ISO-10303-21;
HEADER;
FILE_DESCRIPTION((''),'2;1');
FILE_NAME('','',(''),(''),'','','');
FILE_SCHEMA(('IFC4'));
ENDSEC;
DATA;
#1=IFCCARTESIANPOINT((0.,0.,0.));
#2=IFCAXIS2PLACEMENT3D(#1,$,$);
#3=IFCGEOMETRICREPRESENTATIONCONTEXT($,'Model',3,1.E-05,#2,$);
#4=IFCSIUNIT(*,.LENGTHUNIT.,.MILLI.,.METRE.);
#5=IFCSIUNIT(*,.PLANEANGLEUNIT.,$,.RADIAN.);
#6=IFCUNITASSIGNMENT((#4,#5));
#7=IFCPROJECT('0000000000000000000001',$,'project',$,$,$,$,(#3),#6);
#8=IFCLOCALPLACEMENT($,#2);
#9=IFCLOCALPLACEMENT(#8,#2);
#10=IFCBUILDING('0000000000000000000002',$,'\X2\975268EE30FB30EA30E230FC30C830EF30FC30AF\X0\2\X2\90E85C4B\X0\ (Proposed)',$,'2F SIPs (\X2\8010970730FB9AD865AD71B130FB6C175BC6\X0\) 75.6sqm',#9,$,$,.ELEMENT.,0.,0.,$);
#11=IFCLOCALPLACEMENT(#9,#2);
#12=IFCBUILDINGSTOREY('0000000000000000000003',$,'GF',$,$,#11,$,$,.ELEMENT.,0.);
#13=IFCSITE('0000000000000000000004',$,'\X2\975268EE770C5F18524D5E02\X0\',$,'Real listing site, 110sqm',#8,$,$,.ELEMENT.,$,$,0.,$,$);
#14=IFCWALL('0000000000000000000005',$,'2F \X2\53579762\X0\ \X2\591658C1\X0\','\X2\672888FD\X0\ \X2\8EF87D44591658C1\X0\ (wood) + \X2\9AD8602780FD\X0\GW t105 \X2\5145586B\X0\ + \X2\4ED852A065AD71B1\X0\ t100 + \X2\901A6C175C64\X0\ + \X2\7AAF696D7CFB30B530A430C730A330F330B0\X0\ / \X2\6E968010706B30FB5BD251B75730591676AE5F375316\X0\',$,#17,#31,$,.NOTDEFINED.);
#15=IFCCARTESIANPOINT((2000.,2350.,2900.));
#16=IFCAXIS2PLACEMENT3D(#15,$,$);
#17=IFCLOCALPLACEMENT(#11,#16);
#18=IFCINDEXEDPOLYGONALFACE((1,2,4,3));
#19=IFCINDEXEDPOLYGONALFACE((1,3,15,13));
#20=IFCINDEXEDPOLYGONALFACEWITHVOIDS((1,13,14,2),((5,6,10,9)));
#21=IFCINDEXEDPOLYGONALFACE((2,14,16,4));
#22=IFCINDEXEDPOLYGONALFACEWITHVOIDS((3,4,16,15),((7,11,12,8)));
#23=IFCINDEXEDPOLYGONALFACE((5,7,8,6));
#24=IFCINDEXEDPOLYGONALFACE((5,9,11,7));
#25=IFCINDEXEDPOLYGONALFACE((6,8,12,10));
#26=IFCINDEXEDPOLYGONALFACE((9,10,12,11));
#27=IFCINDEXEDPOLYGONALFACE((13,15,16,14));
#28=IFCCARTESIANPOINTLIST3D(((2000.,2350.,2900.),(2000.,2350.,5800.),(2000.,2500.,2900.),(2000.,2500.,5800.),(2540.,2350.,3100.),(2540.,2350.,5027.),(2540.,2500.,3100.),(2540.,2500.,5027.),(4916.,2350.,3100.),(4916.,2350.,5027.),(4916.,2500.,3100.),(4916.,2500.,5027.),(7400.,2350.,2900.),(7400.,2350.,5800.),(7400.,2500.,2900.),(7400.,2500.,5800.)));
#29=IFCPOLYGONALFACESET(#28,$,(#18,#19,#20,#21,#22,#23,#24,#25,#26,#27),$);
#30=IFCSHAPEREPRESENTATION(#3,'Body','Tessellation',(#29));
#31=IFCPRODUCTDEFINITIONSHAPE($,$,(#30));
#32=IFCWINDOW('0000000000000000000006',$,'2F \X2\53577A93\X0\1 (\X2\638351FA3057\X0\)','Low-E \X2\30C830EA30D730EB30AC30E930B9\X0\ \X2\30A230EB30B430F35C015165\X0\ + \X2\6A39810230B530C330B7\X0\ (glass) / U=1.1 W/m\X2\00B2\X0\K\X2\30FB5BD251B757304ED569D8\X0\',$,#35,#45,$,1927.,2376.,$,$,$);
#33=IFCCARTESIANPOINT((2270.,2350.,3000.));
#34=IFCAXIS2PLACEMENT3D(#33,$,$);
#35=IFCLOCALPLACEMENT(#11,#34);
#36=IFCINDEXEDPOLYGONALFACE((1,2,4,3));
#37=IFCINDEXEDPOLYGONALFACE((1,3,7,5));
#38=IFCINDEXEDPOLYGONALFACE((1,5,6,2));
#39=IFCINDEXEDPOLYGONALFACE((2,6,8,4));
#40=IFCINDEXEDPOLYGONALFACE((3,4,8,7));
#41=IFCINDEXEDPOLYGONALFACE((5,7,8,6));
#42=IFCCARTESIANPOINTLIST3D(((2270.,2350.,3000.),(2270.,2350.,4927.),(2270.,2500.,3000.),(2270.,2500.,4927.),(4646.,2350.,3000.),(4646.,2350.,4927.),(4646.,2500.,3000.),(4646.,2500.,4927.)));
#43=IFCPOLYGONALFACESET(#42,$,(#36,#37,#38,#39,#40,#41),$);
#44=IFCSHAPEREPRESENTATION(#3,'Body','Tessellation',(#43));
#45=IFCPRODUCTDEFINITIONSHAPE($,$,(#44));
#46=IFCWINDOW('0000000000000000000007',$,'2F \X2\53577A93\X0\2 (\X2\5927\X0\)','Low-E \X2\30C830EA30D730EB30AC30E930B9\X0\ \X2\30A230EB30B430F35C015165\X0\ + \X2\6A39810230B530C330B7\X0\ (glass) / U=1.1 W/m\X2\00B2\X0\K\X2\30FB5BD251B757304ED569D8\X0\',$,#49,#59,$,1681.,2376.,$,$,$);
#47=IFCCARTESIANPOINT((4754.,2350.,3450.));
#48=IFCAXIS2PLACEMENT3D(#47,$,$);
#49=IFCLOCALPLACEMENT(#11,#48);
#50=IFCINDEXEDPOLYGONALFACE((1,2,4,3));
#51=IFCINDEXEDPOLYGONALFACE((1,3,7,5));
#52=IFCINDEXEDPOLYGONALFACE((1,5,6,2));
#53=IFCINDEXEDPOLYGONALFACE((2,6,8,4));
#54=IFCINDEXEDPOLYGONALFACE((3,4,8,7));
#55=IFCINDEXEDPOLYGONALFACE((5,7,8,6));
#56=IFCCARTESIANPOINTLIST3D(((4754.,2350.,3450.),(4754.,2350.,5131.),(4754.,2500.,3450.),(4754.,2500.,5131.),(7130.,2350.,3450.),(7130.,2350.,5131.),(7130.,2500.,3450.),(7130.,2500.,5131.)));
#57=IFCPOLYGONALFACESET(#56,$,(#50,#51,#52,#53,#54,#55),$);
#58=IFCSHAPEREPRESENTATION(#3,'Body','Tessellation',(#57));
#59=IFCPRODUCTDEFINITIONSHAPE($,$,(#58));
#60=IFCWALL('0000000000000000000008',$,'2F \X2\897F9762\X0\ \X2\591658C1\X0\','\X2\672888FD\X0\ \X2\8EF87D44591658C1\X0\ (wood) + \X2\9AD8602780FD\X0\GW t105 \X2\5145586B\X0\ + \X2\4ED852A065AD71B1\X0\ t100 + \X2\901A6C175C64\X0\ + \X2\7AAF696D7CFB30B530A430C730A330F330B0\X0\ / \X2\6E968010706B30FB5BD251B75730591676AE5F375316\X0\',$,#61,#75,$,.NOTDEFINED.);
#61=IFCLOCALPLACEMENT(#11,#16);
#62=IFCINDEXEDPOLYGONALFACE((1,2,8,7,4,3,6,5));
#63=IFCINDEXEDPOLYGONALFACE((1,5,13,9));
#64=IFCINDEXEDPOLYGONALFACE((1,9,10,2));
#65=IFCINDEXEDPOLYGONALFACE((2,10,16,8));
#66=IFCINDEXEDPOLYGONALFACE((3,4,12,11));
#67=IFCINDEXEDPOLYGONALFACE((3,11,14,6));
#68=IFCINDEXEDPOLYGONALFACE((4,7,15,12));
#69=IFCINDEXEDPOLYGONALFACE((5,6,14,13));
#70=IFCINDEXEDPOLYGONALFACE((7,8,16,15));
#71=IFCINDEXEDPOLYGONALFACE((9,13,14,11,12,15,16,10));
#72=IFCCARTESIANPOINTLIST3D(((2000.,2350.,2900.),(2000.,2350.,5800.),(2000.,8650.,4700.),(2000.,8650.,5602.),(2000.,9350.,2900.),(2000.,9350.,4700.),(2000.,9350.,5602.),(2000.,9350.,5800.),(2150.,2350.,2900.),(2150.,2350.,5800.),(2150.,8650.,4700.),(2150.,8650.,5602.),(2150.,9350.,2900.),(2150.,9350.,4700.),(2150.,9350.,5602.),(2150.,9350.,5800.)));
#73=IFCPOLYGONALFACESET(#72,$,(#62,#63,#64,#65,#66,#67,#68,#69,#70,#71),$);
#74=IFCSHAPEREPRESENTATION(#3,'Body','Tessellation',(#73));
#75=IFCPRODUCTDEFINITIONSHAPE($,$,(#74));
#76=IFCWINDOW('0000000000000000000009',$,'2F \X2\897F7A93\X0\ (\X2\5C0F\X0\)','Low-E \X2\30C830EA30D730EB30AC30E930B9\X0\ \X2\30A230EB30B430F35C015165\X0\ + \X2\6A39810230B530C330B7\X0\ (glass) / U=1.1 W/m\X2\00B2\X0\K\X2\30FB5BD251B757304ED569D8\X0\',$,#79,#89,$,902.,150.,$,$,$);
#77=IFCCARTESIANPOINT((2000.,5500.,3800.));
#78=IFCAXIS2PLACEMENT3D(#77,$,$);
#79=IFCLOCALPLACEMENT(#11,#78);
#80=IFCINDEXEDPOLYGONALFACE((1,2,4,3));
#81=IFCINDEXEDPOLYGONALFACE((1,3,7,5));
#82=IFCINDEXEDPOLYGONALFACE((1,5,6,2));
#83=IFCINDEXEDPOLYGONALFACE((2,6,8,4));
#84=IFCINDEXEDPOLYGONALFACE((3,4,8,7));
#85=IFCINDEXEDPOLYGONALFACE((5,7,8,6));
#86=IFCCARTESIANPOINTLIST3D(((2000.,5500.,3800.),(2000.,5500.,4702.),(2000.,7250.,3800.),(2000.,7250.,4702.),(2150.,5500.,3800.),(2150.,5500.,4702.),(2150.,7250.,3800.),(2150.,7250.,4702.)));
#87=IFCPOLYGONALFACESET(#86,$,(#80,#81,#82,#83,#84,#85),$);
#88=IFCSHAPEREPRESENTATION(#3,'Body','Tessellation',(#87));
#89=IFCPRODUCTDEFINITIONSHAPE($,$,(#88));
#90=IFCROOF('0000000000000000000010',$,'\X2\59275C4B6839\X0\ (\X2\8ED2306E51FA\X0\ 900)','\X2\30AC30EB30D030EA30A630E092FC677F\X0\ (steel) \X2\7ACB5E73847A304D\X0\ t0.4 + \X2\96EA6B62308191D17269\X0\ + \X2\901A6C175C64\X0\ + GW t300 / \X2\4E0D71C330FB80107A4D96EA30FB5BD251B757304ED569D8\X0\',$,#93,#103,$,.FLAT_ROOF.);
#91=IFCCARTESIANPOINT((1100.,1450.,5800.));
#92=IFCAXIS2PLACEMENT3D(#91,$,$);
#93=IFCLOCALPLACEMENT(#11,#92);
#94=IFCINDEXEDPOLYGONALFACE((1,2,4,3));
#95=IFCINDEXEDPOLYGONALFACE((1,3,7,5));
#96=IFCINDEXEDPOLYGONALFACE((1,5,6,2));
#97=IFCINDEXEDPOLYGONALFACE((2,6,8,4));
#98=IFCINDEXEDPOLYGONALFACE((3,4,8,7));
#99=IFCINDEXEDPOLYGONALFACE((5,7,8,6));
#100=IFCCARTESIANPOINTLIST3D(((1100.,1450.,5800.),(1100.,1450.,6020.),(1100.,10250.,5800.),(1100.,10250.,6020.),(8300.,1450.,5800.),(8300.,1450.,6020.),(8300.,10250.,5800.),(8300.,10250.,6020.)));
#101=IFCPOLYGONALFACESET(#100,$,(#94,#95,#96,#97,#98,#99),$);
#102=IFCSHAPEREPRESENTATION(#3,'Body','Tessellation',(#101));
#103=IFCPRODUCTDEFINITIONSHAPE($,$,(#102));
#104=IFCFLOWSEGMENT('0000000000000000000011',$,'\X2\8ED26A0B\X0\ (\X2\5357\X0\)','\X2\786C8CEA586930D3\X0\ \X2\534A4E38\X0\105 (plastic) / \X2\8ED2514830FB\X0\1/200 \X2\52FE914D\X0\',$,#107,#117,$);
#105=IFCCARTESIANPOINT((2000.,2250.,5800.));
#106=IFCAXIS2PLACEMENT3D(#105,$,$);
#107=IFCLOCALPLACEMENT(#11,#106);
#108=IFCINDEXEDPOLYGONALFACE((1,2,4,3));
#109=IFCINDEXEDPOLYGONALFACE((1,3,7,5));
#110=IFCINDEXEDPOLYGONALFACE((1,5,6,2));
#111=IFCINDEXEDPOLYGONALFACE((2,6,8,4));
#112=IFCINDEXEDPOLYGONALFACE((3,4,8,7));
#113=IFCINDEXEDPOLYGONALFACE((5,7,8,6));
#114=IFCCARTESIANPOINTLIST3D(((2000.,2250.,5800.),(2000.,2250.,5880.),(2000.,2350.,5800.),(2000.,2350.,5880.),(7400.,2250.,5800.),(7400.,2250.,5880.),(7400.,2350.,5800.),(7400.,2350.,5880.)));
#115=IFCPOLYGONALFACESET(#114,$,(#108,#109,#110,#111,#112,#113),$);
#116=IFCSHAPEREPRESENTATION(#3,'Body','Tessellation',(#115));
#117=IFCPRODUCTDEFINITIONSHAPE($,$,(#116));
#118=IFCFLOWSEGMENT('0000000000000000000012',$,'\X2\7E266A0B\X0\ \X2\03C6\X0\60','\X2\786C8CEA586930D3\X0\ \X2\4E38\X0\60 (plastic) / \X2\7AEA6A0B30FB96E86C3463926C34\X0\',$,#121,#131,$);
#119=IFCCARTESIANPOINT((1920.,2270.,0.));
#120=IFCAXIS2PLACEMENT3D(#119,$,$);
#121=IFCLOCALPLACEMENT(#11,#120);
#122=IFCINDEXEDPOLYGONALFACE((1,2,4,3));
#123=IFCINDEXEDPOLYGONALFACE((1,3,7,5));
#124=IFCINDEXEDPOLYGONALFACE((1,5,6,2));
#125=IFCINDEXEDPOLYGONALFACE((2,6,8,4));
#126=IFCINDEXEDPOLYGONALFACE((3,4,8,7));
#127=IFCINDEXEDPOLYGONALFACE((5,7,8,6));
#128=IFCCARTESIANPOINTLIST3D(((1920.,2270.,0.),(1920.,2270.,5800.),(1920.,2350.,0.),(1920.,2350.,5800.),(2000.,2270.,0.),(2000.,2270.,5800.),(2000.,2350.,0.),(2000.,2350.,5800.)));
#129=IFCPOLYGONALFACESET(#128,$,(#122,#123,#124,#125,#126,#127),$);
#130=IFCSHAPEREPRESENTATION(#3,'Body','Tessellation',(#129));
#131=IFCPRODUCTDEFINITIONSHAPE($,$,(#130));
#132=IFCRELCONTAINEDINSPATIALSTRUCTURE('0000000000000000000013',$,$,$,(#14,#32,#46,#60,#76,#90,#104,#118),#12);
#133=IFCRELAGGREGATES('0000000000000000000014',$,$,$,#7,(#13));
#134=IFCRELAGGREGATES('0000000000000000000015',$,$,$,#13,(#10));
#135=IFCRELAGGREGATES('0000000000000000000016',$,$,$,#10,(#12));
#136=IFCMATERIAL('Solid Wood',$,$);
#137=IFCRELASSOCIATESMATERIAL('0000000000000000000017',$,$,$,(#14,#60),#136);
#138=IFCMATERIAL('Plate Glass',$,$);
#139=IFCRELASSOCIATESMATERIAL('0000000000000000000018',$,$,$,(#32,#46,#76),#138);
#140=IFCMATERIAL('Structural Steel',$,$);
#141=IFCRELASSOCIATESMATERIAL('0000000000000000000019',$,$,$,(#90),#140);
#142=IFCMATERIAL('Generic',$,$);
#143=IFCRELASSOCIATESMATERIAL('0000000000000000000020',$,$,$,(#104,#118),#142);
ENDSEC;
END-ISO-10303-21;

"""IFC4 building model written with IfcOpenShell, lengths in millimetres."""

from ifc_helpers import new_model, si_unit, frame, frame_2d, origin, place, context, project, spatial, rectangle, extrude, material, element, fill, save


model = new_model("IFC4")

# Units and contexts
model_context = context("Model", 3, precision=1e-05, world=origin())
ifc_project = project(units=[si_unit("LENGTHUNIT", "METRE", prefix="MILLI"), si_unit("PLANEANGLEUNIT", "RADIAN")], contexts=[model_context])

# Site, building, storey
site_placement = place(None, origin())
site = spatial("IfcSite", under=ifc_project, at=site_placement, Name="青森県弘前市", ObjectType="Real listing site, 110sqm", CompositionType="ELEMENT", RefElevation=0.0)
building_placement = place(site_placement, origin())
building = spatial("IfcBuilding", under=site, at=building_placement, Name="青森・リモートワーク2部屋 (Proposed)", ObjectType="2F SIPs (耐震・高断熱・気密) 75.6sqm", CompositionType="ELEMENT", ElevationOfRefHeight=0.0, ElevationOfTerrain=0.0)
storey_placement = place(building_placement, origin())
storey = spatial("IfcBuildingStorey", under=building, at=storey_placement, Name="GF", CompositionType="ELEMENT", Elevation=0.0)

# Shared definitions
ifc_material_1 = material(Name="Solid Wood")

# Shared definitions
ifc_material_2 = material(Name="Plate Glass")

# Wall, openings, windows
wall_1_placement = place(storey_placement, frame((2000.0, 2350.0, 2900.0)))
wall_1 = element("IfcWall", 1, at=wall_1_placement, inside=storey, material=ifc_material_1, Name="2F 南面 外壁", Description="木製 軸組外壁 (wood) + 高性能GW t105 充填 + 付加断熱 t100 + 通気層 + 窯業系サイディング / 準耐火・寒冷地外皮強化", PredefinedType="NOTDEFINED", context=model_context, shape_type="SweptSolid", body=[
    extrude(rectangle(XDim=5400.0, YDim=150.0, at=frame_2d((2700.0, 75.0))), frame((2000.0, 2350.0, 2900.0)), (0.0, 0.0, 1.0), 2900.0),
])
opening_1_placement = place(storey_placement, frame((2270.0, 2350.0, 3000.0)))
opening_1 = element("IfcOpeningElement", 2, at=opening_1_placement, cuts=wall_1, PredefinedType="NOTDEFINED", context=model_context, shape_type="SweptSolid", body=[
    extrude(rectangle(XDim=2376.0, YDim=150.0, at=frame_2d((1188.0, 75.0))), frame((2270.0, 2350.0, 3000.0)), (0.0, 0.0, 1.0), 1927.0),
])
opening_2_placement = place(storey_placement, frame((4754.0, 2350.0, 3450.0)))
opening_2 = element("IfcOpeningElement", 3, at=opening_2_placement, cuts=wall_1, PredefinedType="NOTDEFINED", context=model_context, shape_type="SweptSolid", body=[
    extrude(rectangle(XDim=2376.0, YDim=150.0, at=frame_2d((1188.0, 75.0))), frame((4754.0, 2350.0, 3450.0)), (0.0, 0.0, 1.0), 1681.0),
])
window_1_placement = place(storey_placement, frame((2270.0, 2350.0, 3000.0)))
window_1 = element("IfcWindow", 4, at=window_1_placement, inside=storey, material=ifc_material_2, Name="2F 南窓1 (掃出し)", Description="Low-E トリプルガラス アルゴン封入 + 樹脂サッシ (glass) / U=1.1 W/m²K・寒冷地仕様", OverallHeight=1927.0, OverallWidth=2376.0, context=model_context, shape_type="SweptSolid", body=[
    extrude(rectangle(XDim=2376.0, YDim=150.0, at=frame_2d((1188.0, 75.0))), frame((2270.0, 2350.0, 3000.0)), (0.0, 0.0, 1.0), 1927.0),
])
fill(opening_1, window_1)
window_2_placement = place(storey_placement, frame((4754.0, 2350.0, 3450.0)))
window_2 = element("IfcWindow", 5, at=window_2_placement, inside=storey, material=ifc_material_2, Name="2F 南窓2 (大)", Description="Low-E トリプルガラス アルゴン封入 + 樹脂サッシ (glass) / U=1.1 W/m²K・寒冷地仕様", OverallHeight=1681.0, OverallWidth=2376.0, context=model_context, shape_type="SweptSolid", body=[
    extrude(rectangle(XDim=2376.0, YDim=150.0, at=frame_2d((1188.0, 75.0))), frame((4754.0, 2350.0, 3450.0)), (0.0, 0.0, 1.0), 1681.0),
])
fill(opening_2, window_2)

# Wall, opening, window
wall_2_placement = place(storey_placement, frame((2000.0, 2350.0, 2900.0)))
wall_2 = element("IfcWall", 6, at=wall_2_placement, inside=storey, material=ifc_material_1, Name="2F 西面 外壁", Description="木製 軸組外壁 (wood) + 高性能GW t105 充填 + 付加断熱 t100 + 通気層 + 窯業系サイディング / 準耐火・寒冷地外皮強化", PredefinedType="NOTDEFINED", context=model_context, shape_type="SweptSolid", body=[
    extrude(rectangle(XDim=150.0, YDim=7000.0, at=frame_2d((75.0, 3500.0))), frame((2000.0, 2350.0, 2900.0)), (0.0, 0.0, 1.0), 2900.0),
])
opening_3_placement = place(storey_placement, frame((2000.0, 5500.0, 3800.0)))
opening_3 = element("IfcOpeningElement", 7, at=opening_3_placement, cuts=wall_2, PredefinedType="NOTDEFINED", context=model_context, shape_type="SweptSolid", body=[
    extrude(rectangle(XDim=150.0, YDim=1750.0, at=frame_2d((75.0, 875.0))), frame((2000.0, 5500.0, 3800.0)), (0.0, 0.0, 1.0), 902.0),
])
window_3_placement = place(storey_placement, frame((2000.0, 5500.0, 3800.0)))
window_3 = element("IfcWindow", 8, at=window_3_placement, inside=storey, material=ifc_material_2, Name="2F 西窓 (小)", Description="Low-E トリプルガラス アルゴン封入 + 樹脂サッシ (glass) / U=1.1 W/m²K・寒冷地仕様", OverallHeight=902.0, OverallWidth=150.0, context=model_context, shape_type="SweptSolid", body=[
    extrude(rectangle(XDim=150.0, YDim=1750.0, at=frame_2d((75.0, 875.0))), frame((2000.0, 5500.0, 3800.0)), (0.0, 0.0, 1.0), 902.0),
])
fill(opening_3, window_3)

# Roof
ifc_material_3 = material(Name="Structural Steel")
roof_placement = place(storey_placement, frame((1100.0, 1450.0, 5800.0)))
element("IfcRoof", 9, at=roof_placement, inside=storey, material=ifc_material_3, Name="大屋根 (軒の出 900)", Description="ガルバリウム鋼板 (steel) 立平葺き t0.4 + 雪止め金物 + 通気層 + GW t300 / 不燃・耐積雪・寒冷地仕様", PredefinedType="FLAT_ROOF", context=model_context, shape_type="SweptSolid", body=[
    extrude(rectangle(XDim=7200.0, YDim=8800.0, at=frame_2d((3600.0, 4400.0))), frame((1100.0, 1450.0, 5800.0)), (0.0, 0.0, 1.0), 220.0),
])

# Flow segments
ifc_material_4 = material(Name="Generic")
flow_segment_1_placement = place(storey_placement, frame((2000.0, 2250.0, 5800.0)))
element("IfcFlowSegment", 10, at=flow_segment_1_placement, inside=storey, material=ifc_material_4, Name="軒樋 (南)", Description="硬質塩ビ 半丸105 (plastic) / 軒先・1/200 勾配", context=model_context, shape_type="SweptSolid", body=[
    extrude(rectangle(XDim=5400.0, YDim=100.0, at=frame_2d((2700.0, 50.0))), frame((2000.0, 2250.0, 5800.0)), (0.0, 0.0, 1.0), 80.0),
])
flow_segment_2_placement = place(storey_placement, frame((1920.0, 2270.0, 0.0)))
element("IfcFlowSegment", 11, at=flow_segment_2_placement, inside=storey, material=ifc_material_4, Name="縦樋 φ60", Description="硬質塩ビ 丸60 (plastic) / 竪樋・雨水排水", context=model_context, shape_type="SweptSolid", body=[
    extrude(rectangle(XDim=80.0, YDim=80.0, at=frame_2d((40.0, 40.0))), frame((1920.0, 2270.0, 0.0)), (0.0, 0.0, 1.0), 5800.0),
])

save(model, "model.ifc")
